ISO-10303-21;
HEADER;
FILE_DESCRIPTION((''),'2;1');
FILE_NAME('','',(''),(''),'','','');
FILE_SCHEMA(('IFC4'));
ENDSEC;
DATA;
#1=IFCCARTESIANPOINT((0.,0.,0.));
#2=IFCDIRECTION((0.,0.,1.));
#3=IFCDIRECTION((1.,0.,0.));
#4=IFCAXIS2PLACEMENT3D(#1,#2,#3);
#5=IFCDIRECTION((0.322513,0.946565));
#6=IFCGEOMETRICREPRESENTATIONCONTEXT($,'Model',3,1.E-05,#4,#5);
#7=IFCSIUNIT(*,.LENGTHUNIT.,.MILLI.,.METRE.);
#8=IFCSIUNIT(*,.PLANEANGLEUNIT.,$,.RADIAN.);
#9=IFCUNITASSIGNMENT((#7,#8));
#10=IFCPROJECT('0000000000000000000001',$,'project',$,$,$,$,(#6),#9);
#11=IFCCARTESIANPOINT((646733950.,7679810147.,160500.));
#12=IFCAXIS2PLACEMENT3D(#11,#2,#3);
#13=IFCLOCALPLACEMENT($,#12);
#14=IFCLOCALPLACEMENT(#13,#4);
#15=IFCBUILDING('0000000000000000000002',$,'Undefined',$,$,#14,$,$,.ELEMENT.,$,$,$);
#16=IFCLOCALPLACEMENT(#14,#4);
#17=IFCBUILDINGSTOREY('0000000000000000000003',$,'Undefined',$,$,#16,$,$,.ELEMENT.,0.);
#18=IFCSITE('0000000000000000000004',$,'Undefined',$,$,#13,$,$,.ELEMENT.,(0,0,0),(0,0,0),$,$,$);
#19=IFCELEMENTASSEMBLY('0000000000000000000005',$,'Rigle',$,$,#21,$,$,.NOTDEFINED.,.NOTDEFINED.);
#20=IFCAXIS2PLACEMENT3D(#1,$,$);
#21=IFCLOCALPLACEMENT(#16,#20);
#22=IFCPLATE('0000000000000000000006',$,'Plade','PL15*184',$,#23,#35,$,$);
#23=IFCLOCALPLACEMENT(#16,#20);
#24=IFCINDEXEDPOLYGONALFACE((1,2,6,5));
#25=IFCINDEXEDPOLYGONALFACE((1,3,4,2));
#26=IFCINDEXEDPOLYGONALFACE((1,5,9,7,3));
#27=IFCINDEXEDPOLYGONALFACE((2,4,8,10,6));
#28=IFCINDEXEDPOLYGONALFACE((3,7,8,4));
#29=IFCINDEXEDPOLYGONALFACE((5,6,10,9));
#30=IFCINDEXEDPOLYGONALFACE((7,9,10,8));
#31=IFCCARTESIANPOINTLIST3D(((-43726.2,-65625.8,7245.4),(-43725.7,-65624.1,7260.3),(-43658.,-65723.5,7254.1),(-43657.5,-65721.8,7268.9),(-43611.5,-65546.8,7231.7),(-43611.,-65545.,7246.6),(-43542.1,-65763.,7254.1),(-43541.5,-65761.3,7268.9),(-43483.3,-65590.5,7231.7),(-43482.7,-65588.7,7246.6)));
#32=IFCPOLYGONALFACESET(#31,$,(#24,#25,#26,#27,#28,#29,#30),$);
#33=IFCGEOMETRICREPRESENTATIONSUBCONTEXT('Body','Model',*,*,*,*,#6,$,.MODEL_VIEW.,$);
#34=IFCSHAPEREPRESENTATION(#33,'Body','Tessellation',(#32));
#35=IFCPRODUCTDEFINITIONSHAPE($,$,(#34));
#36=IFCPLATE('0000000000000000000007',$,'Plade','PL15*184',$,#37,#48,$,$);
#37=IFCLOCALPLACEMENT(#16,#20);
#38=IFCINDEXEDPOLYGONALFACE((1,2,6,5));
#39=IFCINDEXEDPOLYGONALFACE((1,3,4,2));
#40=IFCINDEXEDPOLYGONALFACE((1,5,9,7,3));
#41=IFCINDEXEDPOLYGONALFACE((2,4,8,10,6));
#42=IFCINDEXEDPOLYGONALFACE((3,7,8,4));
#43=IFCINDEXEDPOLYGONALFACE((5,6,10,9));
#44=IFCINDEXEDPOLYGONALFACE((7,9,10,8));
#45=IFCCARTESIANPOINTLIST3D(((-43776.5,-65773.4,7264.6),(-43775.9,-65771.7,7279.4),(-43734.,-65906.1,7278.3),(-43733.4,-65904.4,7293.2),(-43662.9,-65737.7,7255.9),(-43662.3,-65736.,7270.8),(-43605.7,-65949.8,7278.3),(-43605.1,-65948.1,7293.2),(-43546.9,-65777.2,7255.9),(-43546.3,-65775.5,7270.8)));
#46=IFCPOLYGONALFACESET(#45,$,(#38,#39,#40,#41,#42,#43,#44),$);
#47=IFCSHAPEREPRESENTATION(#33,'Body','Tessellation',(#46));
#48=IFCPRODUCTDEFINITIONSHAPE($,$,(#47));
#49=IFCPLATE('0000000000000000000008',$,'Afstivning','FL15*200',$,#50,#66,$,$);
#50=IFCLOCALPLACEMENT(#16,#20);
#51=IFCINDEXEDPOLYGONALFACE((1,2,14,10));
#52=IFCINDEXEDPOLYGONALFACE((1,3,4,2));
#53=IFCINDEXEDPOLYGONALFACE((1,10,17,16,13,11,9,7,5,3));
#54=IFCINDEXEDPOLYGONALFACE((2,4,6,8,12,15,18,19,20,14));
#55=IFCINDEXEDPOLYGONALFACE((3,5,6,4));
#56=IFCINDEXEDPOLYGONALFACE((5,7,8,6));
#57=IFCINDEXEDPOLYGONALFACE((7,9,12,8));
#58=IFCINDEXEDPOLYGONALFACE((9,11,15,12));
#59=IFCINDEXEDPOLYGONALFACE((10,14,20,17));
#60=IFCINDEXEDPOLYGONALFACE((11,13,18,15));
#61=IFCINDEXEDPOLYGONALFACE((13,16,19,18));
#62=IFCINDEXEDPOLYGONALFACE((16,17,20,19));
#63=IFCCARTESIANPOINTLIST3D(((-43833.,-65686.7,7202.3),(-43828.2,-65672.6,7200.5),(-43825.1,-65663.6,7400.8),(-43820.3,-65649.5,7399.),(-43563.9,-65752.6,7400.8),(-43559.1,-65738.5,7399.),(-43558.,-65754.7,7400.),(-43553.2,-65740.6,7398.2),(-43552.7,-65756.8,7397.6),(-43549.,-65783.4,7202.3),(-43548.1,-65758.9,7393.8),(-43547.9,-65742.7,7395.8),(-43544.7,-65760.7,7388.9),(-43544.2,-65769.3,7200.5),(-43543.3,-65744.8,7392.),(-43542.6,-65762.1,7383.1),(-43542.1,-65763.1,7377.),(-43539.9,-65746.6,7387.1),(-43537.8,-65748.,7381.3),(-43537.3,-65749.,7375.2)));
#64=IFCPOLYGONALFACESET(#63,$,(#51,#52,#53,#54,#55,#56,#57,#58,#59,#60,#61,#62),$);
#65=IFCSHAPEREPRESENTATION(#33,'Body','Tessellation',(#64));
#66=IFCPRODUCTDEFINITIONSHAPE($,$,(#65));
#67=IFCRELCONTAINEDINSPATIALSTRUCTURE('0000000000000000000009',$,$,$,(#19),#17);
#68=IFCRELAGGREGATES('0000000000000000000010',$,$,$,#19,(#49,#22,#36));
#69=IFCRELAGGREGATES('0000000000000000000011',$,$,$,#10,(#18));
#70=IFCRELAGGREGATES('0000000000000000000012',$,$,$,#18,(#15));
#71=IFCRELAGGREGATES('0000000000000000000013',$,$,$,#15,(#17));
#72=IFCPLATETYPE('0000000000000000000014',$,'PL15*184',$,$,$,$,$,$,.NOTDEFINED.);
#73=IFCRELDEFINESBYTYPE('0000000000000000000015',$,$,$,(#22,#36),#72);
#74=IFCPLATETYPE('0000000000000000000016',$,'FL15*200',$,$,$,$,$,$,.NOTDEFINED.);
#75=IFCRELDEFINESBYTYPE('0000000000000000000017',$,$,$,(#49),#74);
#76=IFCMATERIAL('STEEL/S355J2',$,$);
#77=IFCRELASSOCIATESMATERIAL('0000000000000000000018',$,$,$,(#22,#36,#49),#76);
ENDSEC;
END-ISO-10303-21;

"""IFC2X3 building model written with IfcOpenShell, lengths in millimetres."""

from ifc_helpers import new_model, si_unit, direction, frame, frame_2d, origin_with_axes, place, context, subcontext, project, spatial, polyline, circle_curve, parameter, trimmed, segment, composite_curve, outline, extrude, material, type_object, element, aggregate, save


model = new_model("IFC2X3")

# Units and contexts
model_context = context("Model", 3, precision=1e-05, world=origin_with_axes(), true_north=direction((0.322513, 0.946565)))
body_context = subcontext(model_context, "Body", "Model", "MODEL_VIEW")
ifc_project = project(units=[si_unit("LENGTHUNIT", "METRE", prefix="MILLI"), si_unit("PLANEANGLEUNIT", "RADIAN")], contexts=[model_context])

# Site, building, storey
site_placement = place(None, frame((646733950.0, 7679810147.0, 160500.0), z_axis=(0.0, 0.0, 1.0), x_axis=(1.0, 0.0, 0.0)))
site = spatial("IfcSite", under=ifc_project, at=site_placement, Name="Undefined", CompositionType="ELEMENT", RefLatitude=(0, 0, 0), RefLongitude=(0, 0, 0))
building_placement = place(site_placement, origin_with_axes())
building = spatial("IfcBuilding", under=site, at=building_placement, Name="Undefined", CompositionType="ELEMENT")
storey_placement = place(building_placement, origin_with_axes())
storey = spatial("IfcBuildingStorey", under=building, at=storey_placement, Name="Undefined", CompositionType="ELEMENT", Elevation=0.0)

# Shared definitions
ifc_material_1 = material(Name="STEEL/S355J2")

# Element assembly, plates
assembly_1_placement = place(storey_placement, origin_with_axes())
assembly_1 = element("IfcElementAssembly", 1, at=assembly_1_placement, inside=storey, Name="Rigle", AssemblyPlace="NOTDEFINED", PredefinedType="NOTDEFINED")
plate_type_1 = type_object("IfcPlateType", Name="PL15*184", PredefinedType="NOTDEFINED")
plate_1_placement = place(assembly_1_placement, frame((-43541.8, -65762.2, 7261.5), z_axis=(0.039304, 0.115357, 0.992546), x_axis=(0.320109, 0.93951, -0.121869)))
plate_1 = element("IfcPlate", 2, at=plate_1_placement, type_object=plate_type_1, material=ifc_material_1, Name="Plade", Description="PL15*184", context=body_context, shape_type="SweptSolid", body=[
    extrude(outline(polyline([(0.0, 0.0), (183.7, 0.0), (183.7, 135.5), (71.0, 218.6), (0.0, 122.5), (0.0, 0.0)])), frame((0.0, 0.0, -7.5), z_axis=(0.0, 0.0, 1.0), x_axis=(1.0, 0.0, 0.0)), (0.0, 0.0, 1.0), 15.0),
])
plate_2_placement = place(assembly_1_placement, frame((-43605.4, -65948.9, 7285.7), z_axis=(0.039304, 0.115357, 0.992546), x_axis=(0.320109, 0.93951, -0.121869)))
plate_2 = element("IfcPlate", 3, at=plate_2_placement, type_object=plate_type_1, material=ifc_material_1, Name="Plade", Description="PL15*184", context=body_context, shape_type="SweptSolid", body=[
    extrude(outline(polyline([(0.0, 0.0), (183.7, 0.0), (183.7, 122.5), (112.7, 218.6), (0.0, 135.5), (0.0, 0.0)])), frame((0.0, 0.0, -7.5), z_axis=(0.0, 0.0, 1.0), x_axis=(1.0, 0.0, 0.0)), (0.0, 0.0, 1.0), 15.0),
])
plate_type_2 = type_object("IfcPlateType", Name="FL15*200", PredefinedType="NOTDEFINED")
plate_3_placement = place(assembly_1_placement, frame((-43546.6, -65776.4, 7201.4), z_axis=(0.320109, 0.93951, -0.121869), x_axis=(-0.946565, 0.322513, 0.0)))
plate_3 = element("IfcPlate", 4, at=plate_3_placement, type_object=plate_type_2, material=ifc_material_1, Name="Afstivning", Description="FL15*200", context=body_context, shape_type="SweptSolid", body=[
    extrude(outline(composite_curve([segment(polyline([(0.0, 0.0), (300.0, 0.0), (300.0, 200.0), (24.0, 200.0)]), True, "CONTINUOUS"), segment(trimmed(circle_curve(frame_2d((24.0, 176.0), x_axis=(0.0, 1.0)), 24.0), [parameter(0.0)], [parameter(1.570796)], True, "PARAMETER"), True, "CONTINUOUS"), segment(polyline([(0.0, 176.0), (0.0, 0.0)]), True, "CONTINUOUS")], self_intersect=True)), frame((0.0, 0.0, -7.5), z_axis=(0.0, 0.0, 1.0), x_axis=(1.0, 0.0, 0.0)), (0.0, 0.0, 1.0), 15.0),
])
aggregate(assembly_1, [plate_3, plate_1, plate_2])

save(model, "model.ifc")
